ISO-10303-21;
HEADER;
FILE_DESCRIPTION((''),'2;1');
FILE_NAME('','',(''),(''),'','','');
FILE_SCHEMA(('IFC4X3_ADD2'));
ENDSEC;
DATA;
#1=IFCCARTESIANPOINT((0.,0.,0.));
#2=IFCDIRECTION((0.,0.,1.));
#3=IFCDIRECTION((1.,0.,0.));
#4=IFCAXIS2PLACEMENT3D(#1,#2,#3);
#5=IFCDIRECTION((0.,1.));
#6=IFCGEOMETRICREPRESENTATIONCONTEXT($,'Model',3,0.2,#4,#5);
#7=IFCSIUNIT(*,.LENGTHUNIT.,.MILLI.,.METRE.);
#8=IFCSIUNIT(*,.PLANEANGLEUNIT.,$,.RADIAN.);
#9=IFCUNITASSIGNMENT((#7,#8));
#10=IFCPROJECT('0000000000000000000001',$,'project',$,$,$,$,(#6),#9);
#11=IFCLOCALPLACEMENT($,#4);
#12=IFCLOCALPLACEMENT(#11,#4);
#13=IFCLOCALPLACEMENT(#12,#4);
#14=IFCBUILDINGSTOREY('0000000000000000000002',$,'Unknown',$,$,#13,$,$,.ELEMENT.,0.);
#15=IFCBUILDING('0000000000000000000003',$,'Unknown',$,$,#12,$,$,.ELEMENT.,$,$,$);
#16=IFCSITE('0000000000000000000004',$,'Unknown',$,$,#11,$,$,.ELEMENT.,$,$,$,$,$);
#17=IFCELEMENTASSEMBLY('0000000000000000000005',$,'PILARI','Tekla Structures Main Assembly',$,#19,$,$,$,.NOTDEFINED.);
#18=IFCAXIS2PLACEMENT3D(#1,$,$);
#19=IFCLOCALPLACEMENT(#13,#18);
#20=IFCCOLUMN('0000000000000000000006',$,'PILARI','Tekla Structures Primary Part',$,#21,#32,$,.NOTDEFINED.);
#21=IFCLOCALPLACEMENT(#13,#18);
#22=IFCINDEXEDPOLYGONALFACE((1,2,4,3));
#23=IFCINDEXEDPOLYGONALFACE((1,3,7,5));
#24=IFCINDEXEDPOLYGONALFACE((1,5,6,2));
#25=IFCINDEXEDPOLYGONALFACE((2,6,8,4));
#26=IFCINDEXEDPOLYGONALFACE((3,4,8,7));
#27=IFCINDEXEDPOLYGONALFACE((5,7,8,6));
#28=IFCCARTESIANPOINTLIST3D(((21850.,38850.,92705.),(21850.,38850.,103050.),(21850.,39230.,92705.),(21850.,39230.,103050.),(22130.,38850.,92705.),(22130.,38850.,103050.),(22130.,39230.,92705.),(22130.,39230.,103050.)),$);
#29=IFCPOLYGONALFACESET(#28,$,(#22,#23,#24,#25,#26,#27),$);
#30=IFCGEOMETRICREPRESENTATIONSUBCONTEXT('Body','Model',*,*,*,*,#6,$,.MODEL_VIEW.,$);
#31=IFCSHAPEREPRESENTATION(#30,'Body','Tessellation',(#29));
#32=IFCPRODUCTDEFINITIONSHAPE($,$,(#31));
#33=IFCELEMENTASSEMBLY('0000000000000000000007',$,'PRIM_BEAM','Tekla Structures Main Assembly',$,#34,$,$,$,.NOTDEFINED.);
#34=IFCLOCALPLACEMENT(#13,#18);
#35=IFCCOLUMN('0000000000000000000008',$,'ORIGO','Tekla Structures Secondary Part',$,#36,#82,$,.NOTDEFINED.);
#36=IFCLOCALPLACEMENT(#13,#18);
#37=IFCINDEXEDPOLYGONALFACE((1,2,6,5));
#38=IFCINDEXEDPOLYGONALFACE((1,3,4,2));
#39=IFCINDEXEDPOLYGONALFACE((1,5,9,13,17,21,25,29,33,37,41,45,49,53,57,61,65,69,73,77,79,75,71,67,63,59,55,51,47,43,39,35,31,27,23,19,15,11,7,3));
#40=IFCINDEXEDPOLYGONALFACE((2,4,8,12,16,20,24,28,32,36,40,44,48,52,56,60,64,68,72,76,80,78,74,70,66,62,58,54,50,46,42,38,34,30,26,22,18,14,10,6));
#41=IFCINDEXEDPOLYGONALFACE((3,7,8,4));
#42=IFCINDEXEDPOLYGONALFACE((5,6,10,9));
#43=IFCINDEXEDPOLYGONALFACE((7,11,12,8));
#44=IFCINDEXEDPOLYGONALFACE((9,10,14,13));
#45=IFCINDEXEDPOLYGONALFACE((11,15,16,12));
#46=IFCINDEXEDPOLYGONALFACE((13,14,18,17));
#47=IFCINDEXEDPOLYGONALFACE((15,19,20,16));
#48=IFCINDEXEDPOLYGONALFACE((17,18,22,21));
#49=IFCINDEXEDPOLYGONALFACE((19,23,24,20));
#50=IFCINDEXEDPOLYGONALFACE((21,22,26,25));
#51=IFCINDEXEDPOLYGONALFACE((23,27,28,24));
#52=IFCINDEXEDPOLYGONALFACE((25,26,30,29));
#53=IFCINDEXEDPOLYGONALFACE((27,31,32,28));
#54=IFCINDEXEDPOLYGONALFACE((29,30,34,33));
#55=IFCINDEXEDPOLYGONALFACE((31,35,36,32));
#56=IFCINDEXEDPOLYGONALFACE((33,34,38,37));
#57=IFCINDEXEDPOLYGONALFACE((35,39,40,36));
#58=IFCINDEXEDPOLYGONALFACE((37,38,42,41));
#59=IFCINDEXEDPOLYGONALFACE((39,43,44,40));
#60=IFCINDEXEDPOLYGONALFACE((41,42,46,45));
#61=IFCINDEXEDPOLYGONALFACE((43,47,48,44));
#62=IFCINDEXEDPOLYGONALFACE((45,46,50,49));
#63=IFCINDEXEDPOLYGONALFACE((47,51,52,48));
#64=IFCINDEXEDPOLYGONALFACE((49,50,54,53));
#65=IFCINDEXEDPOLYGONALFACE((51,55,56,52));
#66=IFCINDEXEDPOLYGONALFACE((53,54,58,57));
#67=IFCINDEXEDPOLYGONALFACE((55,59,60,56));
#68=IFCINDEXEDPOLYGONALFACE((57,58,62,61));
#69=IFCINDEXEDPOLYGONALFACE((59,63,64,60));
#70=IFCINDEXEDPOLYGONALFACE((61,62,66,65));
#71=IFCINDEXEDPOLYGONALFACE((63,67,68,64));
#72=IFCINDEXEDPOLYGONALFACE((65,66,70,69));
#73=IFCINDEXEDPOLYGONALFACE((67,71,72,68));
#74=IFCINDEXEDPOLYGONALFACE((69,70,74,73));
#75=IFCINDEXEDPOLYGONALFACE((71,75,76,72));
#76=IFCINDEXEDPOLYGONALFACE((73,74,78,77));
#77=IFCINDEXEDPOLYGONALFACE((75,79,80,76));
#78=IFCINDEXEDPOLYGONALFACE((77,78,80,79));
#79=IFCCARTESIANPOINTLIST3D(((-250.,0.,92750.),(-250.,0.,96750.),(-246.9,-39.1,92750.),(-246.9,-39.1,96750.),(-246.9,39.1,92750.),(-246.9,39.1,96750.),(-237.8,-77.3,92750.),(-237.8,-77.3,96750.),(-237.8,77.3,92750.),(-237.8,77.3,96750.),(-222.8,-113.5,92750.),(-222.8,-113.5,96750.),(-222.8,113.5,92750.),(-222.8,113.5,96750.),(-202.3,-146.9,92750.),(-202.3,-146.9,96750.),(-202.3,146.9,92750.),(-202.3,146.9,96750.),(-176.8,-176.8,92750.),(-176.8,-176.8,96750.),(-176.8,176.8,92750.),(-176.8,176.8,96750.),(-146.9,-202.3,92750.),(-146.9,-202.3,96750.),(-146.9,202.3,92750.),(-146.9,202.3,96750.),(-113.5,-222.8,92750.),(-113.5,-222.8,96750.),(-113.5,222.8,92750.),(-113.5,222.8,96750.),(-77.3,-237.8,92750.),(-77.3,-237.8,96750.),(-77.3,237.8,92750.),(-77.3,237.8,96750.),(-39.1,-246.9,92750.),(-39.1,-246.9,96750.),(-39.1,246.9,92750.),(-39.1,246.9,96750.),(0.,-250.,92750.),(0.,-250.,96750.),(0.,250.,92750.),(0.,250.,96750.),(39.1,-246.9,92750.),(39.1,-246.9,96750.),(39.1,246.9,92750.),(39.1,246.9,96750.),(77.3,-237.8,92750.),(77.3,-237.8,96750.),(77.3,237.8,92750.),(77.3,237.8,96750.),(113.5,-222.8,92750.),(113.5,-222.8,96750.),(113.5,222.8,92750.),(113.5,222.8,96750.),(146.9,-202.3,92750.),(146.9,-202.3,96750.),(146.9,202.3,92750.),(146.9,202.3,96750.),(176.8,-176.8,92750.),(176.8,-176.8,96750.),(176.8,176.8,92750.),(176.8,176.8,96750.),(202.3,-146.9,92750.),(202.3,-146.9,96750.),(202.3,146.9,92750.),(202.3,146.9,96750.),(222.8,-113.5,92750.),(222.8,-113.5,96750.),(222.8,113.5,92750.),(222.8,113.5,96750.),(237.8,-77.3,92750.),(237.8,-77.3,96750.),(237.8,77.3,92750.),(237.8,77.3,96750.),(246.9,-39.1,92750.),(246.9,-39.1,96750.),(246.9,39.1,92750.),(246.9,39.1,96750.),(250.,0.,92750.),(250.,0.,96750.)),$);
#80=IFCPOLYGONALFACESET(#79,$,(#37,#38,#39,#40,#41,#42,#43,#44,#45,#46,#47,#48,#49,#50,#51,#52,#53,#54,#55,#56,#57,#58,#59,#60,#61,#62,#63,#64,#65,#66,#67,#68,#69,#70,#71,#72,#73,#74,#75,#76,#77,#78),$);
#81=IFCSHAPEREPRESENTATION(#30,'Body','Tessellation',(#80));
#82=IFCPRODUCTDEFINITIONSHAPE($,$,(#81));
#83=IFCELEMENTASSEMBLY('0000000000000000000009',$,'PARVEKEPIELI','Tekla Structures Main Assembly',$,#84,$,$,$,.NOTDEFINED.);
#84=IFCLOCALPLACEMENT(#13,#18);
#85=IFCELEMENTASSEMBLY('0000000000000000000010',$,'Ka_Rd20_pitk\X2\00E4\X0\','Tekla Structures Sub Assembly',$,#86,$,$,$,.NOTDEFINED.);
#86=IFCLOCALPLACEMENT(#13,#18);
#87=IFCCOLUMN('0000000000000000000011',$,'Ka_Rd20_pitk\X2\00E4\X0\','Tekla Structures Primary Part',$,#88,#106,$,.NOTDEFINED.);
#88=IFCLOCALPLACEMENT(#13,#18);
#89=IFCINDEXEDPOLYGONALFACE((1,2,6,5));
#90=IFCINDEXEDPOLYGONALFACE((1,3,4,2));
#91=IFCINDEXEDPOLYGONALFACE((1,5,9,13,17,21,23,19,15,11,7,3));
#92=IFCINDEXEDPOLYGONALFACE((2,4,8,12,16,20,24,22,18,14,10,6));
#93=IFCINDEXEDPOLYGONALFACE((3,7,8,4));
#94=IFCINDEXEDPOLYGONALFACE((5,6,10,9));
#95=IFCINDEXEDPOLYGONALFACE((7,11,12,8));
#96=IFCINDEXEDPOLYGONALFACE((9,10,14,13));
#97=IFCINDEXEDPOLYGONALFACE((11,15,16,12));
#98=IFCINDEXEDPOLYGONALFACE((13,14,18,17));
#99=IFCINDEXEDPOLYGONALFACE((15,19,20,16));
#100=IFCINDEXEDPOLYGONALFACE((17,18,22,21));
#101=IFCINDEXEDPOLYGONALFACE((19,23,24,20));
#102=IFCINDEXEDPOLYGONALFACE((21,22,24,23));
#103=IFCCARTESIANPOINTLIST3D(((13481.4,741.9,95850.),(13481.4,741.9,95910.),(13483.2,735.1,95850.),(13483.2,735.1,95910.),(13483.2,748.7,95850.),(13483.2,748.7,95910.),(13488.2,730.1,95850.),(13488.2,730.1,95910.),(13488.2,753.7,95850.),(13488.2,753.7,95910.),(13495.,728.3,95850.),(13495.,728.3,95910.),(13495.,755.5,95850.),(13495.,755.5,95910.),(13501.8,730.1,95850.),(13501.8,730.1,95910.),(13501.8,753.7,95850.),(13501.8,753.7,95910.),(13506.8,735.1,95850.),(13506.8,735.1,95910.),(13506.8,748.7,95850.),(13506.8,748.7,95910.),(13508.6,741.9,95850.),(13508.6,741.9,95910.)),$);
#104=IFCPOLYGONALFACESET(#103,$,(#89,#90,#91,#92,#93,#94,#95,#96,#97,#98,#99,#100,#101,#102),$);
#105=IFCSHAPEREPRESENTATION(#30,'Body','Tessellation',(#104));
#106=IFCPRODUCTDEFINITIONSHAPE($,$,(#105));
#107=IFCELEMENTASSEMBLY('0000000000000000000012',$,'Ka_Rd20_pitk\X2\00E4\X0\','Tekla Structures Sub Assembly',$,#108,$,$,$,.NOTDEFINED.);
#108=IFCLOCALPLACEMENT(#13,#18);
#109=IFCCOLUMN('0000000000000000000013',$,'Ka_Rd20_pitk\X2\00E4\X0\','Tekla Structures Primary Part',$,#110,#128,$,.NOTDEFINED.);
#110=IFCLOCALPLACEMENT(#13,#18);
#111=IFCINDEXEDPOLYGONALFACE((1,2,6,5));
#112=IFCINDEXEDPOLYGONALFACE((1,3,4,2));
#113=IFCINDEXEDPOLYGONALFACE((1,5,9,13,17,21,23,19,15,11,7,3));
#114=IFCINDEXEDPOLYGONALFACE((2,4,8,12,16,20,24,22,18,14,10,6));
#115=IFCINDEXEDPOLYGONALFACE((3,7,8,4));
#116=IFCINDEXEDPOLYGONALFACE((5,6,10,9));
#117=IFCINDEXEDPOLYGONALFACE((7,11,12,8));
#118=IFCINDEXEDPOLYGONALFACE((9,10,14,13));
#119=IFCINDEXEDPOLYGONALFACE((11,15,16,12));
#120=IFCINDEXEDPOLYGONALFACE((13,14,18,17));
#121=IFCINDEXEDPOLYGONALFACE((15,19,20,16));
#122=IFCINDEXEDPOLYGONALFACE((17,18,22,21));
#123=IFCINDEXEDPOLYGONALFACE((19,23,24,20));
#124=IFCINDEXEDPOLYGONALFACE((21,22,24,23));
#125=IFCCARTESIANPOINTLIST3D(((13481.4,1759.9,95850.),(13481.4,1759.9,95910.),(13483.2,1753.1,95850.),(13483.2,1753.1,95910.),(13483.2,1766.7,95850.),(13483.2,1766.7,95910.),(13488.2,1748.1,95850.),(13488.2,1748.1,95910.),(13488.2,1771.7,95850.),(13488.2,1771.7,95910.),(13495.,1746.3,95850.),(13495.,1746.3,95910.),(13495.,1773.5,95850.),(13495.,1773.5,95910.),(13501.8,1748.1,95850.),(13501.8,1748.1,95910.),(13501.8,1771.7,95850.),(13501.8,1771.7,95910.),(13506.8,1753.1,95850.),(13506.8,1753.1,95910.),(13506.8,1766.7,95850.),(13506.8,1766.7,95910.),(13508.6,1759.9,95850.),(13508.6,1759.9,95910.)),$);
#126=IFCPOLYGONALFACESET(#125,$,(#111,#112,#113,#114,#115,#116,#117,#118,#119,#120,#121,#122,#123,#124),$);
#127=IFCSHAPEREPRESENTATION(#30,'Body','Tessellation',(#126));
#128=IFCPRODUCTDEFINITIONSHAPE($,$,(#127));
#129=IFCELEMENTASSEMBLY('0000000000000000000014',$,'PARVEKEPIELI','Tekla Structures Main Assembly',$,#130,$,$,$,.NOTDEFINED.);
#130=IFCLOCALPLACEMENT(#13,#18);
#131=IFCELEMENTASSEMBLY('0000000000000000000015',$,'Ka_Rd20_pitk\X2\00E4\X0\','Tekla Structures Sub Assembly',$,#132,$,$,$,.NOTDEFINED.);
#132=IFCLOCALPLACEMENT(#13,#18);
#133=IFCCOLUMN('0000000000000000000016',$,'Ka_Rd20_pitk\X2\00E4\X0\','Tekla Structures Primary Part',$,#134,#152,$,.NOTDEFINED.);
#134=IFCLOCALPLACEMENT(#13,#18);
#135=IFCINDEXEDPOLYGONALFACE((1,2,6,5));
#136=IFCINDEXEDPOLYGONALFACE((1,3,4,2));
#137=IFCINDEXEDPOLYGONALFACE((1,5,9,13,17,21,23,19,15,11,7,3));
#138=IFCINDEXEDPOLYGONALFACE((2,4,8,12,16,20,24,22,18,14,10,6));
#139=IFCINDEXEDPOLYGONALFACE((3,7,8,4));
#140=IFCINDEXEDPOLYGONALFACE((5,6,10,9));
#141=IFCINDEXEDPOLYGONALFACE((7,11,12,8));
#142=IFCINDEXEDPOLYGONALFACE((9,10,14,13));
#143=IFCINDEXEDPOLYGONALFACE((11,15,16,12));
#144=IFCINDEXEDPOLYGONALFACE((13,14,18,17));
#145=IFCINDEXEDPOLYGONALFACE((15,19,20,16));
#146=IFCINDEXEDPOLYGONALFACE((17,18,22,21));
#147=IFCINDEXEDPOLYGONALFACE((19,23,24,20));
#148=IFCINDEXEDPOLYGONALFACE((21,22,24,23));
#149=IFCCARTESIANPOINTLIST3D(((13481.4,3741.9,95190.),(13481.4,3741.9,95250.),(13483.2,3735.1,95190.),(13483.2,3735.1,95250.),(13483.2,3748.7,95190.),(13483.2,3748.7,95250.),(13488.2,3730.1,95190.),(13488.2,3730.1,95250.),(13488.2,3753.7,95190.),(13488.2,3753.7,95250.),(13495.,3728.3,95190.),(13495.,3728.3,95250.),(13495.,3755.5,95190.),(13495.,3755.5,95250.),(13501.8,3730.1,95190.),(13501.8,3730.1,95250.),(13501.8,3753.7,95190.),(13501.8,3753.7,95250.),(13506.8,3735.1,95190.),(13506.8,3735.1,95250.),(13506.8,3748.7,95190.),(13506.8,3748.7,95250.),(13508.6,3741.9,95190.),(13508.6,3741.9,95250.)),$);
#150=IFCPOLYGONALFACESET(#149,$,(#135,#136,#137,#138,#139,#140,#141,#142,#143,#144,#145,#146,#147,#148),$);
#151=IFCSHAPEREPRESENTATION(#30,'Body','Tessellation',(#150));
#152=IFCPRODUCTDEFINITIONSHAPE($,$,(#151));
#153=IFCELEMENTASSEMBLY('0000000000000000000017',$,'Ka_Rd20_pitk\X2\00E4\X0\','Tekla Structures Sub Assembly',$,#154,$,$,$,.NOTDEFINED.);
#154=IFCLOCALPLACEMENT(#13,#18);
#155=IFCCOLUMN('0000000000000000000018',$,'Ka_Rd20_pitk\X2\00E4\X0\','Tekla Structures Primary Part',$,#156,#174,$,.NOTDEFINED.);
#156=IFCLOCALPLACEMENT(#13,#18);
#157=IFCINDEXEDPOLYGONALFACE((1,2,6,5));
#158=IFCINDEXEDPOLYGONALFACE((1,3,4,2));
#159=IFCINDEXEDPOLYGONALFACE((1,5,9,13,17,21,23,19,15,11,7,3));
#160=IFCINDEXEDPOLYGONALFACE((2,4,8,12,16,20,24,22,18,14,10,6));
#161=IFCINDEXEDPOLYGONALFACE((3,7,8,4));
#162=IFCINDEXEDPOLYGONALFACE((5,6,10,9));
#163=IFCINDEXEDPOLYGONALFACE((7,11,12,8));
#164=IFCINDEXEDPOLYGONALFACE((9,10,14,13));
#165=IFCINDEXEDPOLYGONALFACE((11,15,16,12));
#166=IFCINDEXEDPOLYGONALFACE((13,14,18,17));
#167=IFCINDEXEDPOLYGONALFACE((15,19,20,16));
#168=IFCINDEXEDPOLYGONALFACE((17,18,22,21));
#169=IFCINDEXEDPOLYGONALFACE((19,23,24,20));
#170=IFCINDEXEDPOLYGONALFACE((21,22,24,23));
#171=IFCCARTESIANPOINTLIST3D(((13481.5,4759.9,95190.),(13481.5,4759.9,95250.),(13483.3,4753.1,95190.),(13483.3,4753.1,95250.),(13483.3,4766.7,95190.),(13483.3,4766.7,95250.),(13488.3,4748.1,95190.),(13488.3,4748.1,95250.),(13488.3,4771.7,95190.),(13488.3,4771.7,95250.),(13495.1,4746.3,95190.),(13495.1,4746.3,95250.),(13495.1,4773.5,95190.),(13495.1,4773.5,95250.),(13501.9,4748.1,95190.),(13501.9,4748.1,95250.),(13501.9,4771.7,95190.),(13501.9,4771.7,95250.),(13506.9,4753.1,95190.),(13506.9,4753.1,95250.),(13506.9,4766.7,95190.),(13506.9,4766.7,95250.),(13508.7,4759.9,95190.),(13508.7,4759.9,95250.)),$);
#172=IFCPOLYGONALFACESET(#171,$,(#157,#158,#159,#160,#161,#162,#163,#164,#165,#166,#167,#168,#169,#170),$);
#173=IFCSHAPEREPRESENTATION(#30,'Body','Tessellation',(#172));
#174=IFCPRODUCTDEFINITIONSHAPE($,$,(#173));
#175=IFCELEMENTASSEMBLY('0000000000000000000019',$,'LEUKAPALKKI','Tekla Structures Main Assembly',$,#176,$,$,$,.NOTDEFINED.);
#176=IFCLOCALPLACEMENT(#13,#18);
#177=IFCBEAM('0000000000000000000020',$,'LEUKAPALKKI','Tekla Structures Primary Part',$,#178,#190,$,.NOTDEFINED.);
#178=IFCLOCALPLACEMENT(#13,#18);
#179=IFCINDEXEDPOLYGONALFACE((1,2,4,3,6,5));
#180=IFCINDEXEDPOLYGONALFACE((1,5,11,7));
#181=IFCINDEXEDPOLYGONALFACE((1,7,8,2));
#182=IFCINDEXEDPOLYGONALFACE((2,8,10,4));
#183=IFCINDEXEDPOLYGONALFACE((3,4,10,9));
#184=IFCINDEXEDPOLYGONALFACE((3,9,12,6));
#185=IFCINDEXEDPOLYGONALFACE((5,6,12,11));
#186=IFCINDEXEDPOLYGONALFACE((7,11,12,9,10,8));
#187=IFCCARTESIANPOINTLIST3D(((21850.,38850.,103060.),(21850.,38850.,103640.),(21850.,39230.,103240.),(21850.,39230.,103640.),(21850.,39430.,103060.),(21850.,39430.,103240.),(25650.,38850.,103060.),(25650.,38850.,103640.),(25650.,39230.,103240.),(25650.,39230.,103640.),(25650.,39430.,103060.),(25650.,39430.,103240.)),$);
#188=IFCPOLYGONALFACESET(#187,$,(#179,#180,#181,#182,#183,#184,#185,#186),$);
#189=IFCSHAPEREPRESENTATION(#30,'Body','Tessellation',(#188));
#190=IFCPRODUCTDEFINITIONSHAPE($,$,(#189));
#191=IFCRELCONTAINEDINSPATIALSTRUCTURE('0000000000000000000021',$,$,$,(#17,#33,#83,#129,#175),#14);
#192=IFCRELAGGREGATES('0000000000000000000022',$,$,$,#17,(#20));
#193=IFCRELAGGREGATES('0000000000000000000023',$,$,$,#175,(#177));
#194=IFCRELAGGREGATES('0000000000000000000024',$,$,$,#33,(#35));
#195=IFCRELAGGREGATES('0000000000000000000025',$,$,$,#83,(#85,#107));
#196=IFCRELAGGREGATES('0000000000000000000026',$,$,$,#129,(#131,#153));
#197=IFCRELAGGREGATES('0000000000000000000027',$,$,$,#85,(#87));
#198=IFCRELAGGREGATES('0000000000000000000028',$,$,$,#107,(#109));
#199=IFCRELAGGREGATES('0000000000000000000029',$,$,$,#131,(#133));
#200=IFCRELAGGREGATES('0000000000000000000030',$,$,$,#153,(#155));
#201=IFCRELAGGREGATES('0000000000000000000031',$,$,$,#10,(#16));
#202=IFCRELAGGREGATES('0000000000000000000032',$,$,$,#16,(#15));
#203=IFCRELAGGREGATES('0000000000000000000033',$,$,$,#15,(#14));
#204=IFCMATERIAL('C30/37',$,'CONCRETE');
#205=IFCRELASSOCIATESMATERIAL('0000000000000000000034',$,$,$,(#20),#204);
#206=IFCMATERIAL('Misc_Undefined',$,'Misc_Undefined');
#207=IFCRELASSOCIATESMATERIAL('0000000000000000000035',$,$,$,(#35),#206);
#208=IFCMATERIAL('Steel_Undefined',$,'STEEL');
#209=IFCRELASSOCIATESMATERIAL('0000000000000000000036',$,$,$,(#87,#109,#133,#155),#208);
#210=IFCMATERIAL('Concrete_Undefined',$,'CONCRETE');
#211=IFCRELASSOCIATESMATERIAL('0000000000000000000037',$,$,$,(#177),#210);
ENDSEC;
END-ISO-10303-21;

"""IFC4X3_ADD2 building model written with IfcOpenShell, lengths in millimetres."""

from ifc_helpers import new_model, si_unit, direction, frame, origin_with_axes, place, context, subcontext, project, spatial, line, indexed_curve, outline, extrude, material, element, aggregate, save


model = new_model("IFC4X3_ADD2")

# Units and contexts
model_context = context("Model", 3, precision=0.2, world=origin_with_axes(), true_north=direction((0.0, 1.0)))
body_context = subcontext(model_context, "Body", "Model", "MODEL_VIEW")
ifc_project = project(units=[si_unit("LENGTHUNIT", "METRE", prefix="MILLI"), si_unit("PLANEANGLEUNIT", "RADIAN")], contexts=[model_context])

# Site, building, storey
site_placement = place(None, origin_with_axes())
site = spatial("IfcSite", under=ifc_project, at=site_placement, Name="Unknown", CompositionType="ELEMENT")
building_placement = place(site_placement, origin_with_axes())
building = spatial("IfcBuilding", under=site, at=building_placement, Name="Unknown", CompositionType="ELEMENT")
storey_placement = place(building_placement, origin_with_axes())
storey = spatial("IfcBuildingStorey", under=building, at=storey_placement, Name="Unknown", CompositionType="ELEMENT", Elevation=0.0)

# Element assembly, column
assembly_1_placement = place(storey_placement, frame((21990.0, 39040.0, 92705.0), z_axis=(0.0, -1.0, 0.0), x_axis=(0.0, 0.0, 1.0)))
assembly_1 = element("IfcElementAssembly", 1, at=assembly_1_placement, inside=storey, Name="PILARI", Description="Tekla Structures Main Assembly", PredefinedType="NOTDEFINED")
ifc_material_1 = material(Name="C30/37", Category="CONCRETE")
column_1_placement = place(assembly_1_placement, origin_with_axes())
column_1 = element("IfcColumn", 2, at=column_1_placement, material=ifc_material_1, Name="PILARI", Description="Tekla Structures Primary Part", PredefinedType="NOTDEFINED", context=body_context, shape_type="SolidModel", body=[
    extrude(outline(indexed_curve([(-190.0, -140.0), (190.0, -140.0), (190.0, 140.0), (-190.0, 140.0)], segments=[line(1, 2, 3, 4, 1)])), frame((0.0, 0.0, 0.0), z_axis=(-1.0, 0.0, 0.0), x_axis=(0.0, 0.0, 1.0)), (0.0, 0.0, -1.0), 10345.0),
])
aggregate(assembly_1, [column_1])

# Element assembly, column
assembly_2_placement = place(storey_placement, frame((0.0, 0.0, 92750.0), z_axis=(-0.207912, -0.978147, 0.0), x_axis=(0.978147, -0.207912, 0.0)))
assembly_2 = element("IfcElementAssembly", 3, at=assembly_2_placement, inside=storey, Name="PRIM_BEAM", Description="Tekla Structures Main Assembly", PredefinedType="NOTDEFINED")
ifc_material_2 = material(Name="Misc_Undefined", Category="Misc_Undefined")
column_2_placement = place(assembly_2_placement, frame((0.0, 0.0, 0.0), z_axis=(0.207912, 0.0, 0.978147), x_axis=(0.0, 1.0, 0.0)))
column_2 = element("IfcColumn", 4, at=column_2_placement, material=ifc_material_2, Name="ORIGO", Description="Tekla Structures Secondary Part", PredefinedType="NOTDEFINED", context=body_context, shape_type="SolidModel", body=[
    extrude(outline(indexed_curve([(250.0, 0.0), (246.9, 39.1), (237.8, 77.3), (222.8, 113.5), (202.3, 146.9), (176.8, 176.8), (146.9, 202.3), (113.5, 222.8), (77.3, 237.8), (39.1, 246.9), (0.0, 250.0), (-39.1, 246.9), (-77.3, 237.8), (-113.5, 222.8), (-146.9, 202.3), (-176.8, 176.8), (-202.3, 146.9), (-222.8, 113.5), (-237.8, 77.3), (-246.9, 39.1), (-250.0, 0.0), (-246.9, -39.1), (-237.8, -77.3), (-222.8, -113.5), (-202.3, -146.9), (-176.8, -176.8), (-146.9, -202.3), (-113.5, -222.8), (-77.3, -237.8), (-39.1, -246.9), (0.0, -250.0), (39.1, -246.9), (77.3, -237.8), (113.5, -222.8), (146.9, -202.3), (176.8, -176.8), (202.3, -146.9), (222.8, -113.5), (237.8, -77.3), (246.9, -39.1)], segments=[line(1, 2, 3, 4, 5, 6, 7, 8, 9, 10, 11, 12, 13, 14, 15, 16, 17, 18, 19, 20, 21, 22, 23, 24, 25, 26, 27, 28, 29, 30, 31, 32, 33, 34, 35, 36, 37, 38, 39, 40, 1)])), frame((0.0, 0.0, 0.0), z_axis=(-1.0, 0.0, 0.0), x_axis=(0.0, 0.0, 1.0)), (0.0, 0.0, -1.0), 4000.0),
])

# Element assemblies, columns
assembly_3_placement = place(storey_placement, frame((13495.0, 341.9, 94460.0), z_axis=(1.0, -0.000056, 0.0), x_axis=(0.000056, 1.0, 0.0)))
assembly_3 = element("IfcElementAssembly", 5, at=assembly_3_placement, inside=storey, Name="PARVEKEPIELI", Description="Tekla Structures Main Assembly", PredefinedType="NOTDEFINED")
assembly_4_placement = place(assembly_3_placement, frame((400.0, 1390.0, 0.0), z_axis=(-1.0, 0.0, 0.000056), x_axis=(0.0, 1.0, 0.0)))
assembly_4 = element("IfcElementAssembly", 6, at=assembly_4_placement, Name="Ka_Rd20_pitkä", Description="Tekla Structures Sub Assembly", PredefinedType="NOTDEFINED")
ifc_material_3 = material(Name="Steel_Undefined", Category="STEEL")
column_3_placement = place(assembly_4_placement, origin_with_axes())
column_3 = element("IfcColumn", 7, at=column_3_placement, material=ifc_material_3, Name="Ka_Rd20_pitkä", Description="Tekla Structures Primary Part", PredefinedType="NOTDEFINED", context=body_context, shape_type="SolidModel", body=[
    extrude(outline(indexed_curve([(13.6, 0.0), (11.8, 6.8), (6.8, 11.8), (0.0, 13.6), (-6.8, 11.8), (-11.8, 6.8), (-13.6, 0.0), (-11.8, -6.8), (-6.8, -11.8), (0.0, -13.6), (6.8, -11.8), (11.8, -6.8)], segments=[line(1, 2, 3, 4, 5, 6, 7, 8, 9, 10, 11, 12, 1)])), frame((0.0, 0.0, 0.0), z_axis=(-1.0, 0.0, 0.0), x_axis=(0.0, 0.0, 1.0)), (0.0, 0.0, -1.0), 60.0),
])
assembly_5_placement = place(assembly_3_placement, frame((1418.0, 1390.0, -0.1), z_axis=(-1.0, 0.0, 0.000056), x_axis=(0.0, 1.0, 0.0)))
assembly_5 = element("IfcElementAssembly", 8, at=assembly_5_placement, Name="Ka_Rd20_pitkä", Description="Tekla Structures Sub Assembly", PredefinedType="NOTDEFINED")
column_4_placement = place(assembly_5_placement, origin_with_axes())
column_4 = element("IfcColumn", 9, at=column_4_placement, material=ifc_material_3, Name="Ka_Rd20_pitkä", Description="Tekla Structures Primary Part", PredefinedType="NOTDEFINED", context=body_context, shape_type="SolidModel", body=[
    extrude(outline(indexed_curve([(13.6, 0.0), (11.8, 6.8), (6.8, 11.8), (0.0, 13.6), (-6.8, 11.8), (-11.8, 6.8), (-13.6, 0.0), (-11.8, -6.8), (-6.8, -11.8), (0.0, -13.6), (6.8, -11.8), (11.8, -6.8)], segments=[line(1, 2, 3, 4, 5, 6, 7, 8, 9, 10, 11, 12, 1)])), frame((0.0, 0.0, 0.0), z_axis=(-1.0, 0.0, 0.0), x_axis=(0.0, 0.0, 1.0)), (0.0, 0.0, -1.0), 60.0),
])
assembly_6_placement = place(storey_placement, frame((13495.0, 3341.9, 94125.0), z_axis=(1.0, -0.000056, 0.0), x_axis=(0.000056, 1.0, 0.0)))
assembly_6 = element("IfcElementAssembly", 10, at=assembly_6_placement, inside=storey, Name="PARVEKEPIELI", Description="Tekla Structures Main Assembly", PredefinedType="NOTDEFINED")
assembly_7_placement = place(assembly_6_placement, frame((400.0, 1065.0, 0.0), z_axis=(-1.0, 0.0, 0.000056), x_axis=(0.0, 1.0, 0.0)))
assembly_7 = element("IfcElementAssembly", 11, at=assembly_7_placement, Name="Ka_Rd20_pitkä", Description="Tekla Structures Sub Assembly", PredefinedType="NOTDEFINED")
column_5_placement = place(assembly_7_placement, origin_with_axes())
column_5 = element("IfcColumn", 12, at=column_5_placement, material=ifc_material_3, Name="Ka_Rd20_pitkä", Description="Tekla Structures Primary Part", PredefinedType="NOTDEFINED", context=body_context, shape_type="SolidModel", body=[
    extrude(outline(indexed_curve([(13.6, 0.0), (11.8, 6.8), (6.8, 11.8), (0.0, 13.6), (-6.8, 11.8), (-11.8, 6.8), (-13.6, 0.0), (-11.8, -6.8), (-6.8, -11.8), (0.0, -13.6), (6.8, -11.8), (11.8, -6.8)], segments=[line(1, 2, 3, 4, 5, 6, 7, 8, 9, 10, 11, 12, 1)])), frame((0.0, 0.0, 0.0), z_axis=(-1.0, 0.0, 0.0), x_axis=(0.0, 0.0, 1.0)), (0.0, 0.0, -1.0), 60.0),
])
assembly_8_placement = place(assembly_6_placement, frame((1418.0, 1065.0, 0.0), z_axis=(-1.0, 0.0, 0.000056), x_axis=(0.0, 1.0, 0.0)))
assembly_8 = element("IfcElementAssembly", 13, at=assembly_8_placement, Name="Ka_Rd20_pitkä", Description="Tekla Structures Sub Assembly", PredefinedType="NOTDEFINED")
column_6_placement = place(assembly_8_placement, origin_with_axes())
column_6 = element("IfcColumn", 14, at=column_6_placement, material=ifc_material_3, Name="Ka_Rd20_pitkä", Description="Tekla Structures Primary Part", PredefinedType="NOTDEFINED", context=body_context, shape_type="SolidModel", body=[
    extrude(outline(indexed_curve([(13.6, 0.0), (11.8, 6.8), (6.8, 11.8), (0.0, 13.6), (-6.8, 11.8), (-11.8, 6.8), (-13.6, 0.0), (-11.8, -6.8), (-6.8, -11.8), (0.0, -13.6), (6.8, -11.8), (11.8, -6.8)], segments=[line(1, 2, 3, 4, 5, 6, 7, 8, 9, 10, 11, 12, 1)])), frame((0.0, 0.0, 0.0), z_axis=(-1.0, 0.0, 0.0), x_axis=(0.0, 0.0, 1.0)), (0.0, 0.0, -1.0), 60.0),
])

# Element assembly, beam
assembly_9_placement = place(storey_placement, frame((25650.0, 39040.0, 103350.0), z_axis=(0.000003, 1.0, 0.0), x_axis=(-1.0, 0.000003, 0.0)))
assembly_9 = element("IfcElementAssembly", 15, at=assembly_9_placement, inside=storey, Name="LEUKAPALKKI", Description="Tekla Structures Main Assembly", PredefinedType="NOTDEFINED")
ifc_material_4 = material(Name="Concrete_Undefined", Category="CONCRETE")
beam_1_placement = place(assembly_9_placement, origin_with_axes())
beam_1 = element("IfcBeam", 16, at=beam_1_placement, material=ifc_material_4, Name="LEUKAPALKKI", Description="Tekla Structures Primary Part", PredefinedType="NOTDEFINED", context=body_context, shape_type="SolidModel", body=[
    extrude(outline(indexed_curve([(-190.0, -290.0), (390.0, -290.0), (390.0, -110.0), (190.0, -110.0), (190.0, 290.0), (-190.0, 290.0)], segments=[line(1, 2, 3, 4, 5, 6, 1)])), frame((0.0, 0.0, 0.0), z_axis=(-1.0, 0.0, 0.0), x_axis=(0.0, 0.0, 1.0)), (0.0, 0.0, -1.0), 3800.0),
])
aggregate(assembly_9, [beam_1])

aggregate(assembly_2, [column_2])

aggregate(assembly_3, [assembly_4, assembly_5])

aggregate(assembly_6, [assembly_7, assembly_8])

aggregate(assembly_4, [column_3])
aggregate(assembly_5, [column_4])
aggregate(assembly_7, [column_5])
aggregate(assembly_8, [column_6])

save(model, "model.ifc")
